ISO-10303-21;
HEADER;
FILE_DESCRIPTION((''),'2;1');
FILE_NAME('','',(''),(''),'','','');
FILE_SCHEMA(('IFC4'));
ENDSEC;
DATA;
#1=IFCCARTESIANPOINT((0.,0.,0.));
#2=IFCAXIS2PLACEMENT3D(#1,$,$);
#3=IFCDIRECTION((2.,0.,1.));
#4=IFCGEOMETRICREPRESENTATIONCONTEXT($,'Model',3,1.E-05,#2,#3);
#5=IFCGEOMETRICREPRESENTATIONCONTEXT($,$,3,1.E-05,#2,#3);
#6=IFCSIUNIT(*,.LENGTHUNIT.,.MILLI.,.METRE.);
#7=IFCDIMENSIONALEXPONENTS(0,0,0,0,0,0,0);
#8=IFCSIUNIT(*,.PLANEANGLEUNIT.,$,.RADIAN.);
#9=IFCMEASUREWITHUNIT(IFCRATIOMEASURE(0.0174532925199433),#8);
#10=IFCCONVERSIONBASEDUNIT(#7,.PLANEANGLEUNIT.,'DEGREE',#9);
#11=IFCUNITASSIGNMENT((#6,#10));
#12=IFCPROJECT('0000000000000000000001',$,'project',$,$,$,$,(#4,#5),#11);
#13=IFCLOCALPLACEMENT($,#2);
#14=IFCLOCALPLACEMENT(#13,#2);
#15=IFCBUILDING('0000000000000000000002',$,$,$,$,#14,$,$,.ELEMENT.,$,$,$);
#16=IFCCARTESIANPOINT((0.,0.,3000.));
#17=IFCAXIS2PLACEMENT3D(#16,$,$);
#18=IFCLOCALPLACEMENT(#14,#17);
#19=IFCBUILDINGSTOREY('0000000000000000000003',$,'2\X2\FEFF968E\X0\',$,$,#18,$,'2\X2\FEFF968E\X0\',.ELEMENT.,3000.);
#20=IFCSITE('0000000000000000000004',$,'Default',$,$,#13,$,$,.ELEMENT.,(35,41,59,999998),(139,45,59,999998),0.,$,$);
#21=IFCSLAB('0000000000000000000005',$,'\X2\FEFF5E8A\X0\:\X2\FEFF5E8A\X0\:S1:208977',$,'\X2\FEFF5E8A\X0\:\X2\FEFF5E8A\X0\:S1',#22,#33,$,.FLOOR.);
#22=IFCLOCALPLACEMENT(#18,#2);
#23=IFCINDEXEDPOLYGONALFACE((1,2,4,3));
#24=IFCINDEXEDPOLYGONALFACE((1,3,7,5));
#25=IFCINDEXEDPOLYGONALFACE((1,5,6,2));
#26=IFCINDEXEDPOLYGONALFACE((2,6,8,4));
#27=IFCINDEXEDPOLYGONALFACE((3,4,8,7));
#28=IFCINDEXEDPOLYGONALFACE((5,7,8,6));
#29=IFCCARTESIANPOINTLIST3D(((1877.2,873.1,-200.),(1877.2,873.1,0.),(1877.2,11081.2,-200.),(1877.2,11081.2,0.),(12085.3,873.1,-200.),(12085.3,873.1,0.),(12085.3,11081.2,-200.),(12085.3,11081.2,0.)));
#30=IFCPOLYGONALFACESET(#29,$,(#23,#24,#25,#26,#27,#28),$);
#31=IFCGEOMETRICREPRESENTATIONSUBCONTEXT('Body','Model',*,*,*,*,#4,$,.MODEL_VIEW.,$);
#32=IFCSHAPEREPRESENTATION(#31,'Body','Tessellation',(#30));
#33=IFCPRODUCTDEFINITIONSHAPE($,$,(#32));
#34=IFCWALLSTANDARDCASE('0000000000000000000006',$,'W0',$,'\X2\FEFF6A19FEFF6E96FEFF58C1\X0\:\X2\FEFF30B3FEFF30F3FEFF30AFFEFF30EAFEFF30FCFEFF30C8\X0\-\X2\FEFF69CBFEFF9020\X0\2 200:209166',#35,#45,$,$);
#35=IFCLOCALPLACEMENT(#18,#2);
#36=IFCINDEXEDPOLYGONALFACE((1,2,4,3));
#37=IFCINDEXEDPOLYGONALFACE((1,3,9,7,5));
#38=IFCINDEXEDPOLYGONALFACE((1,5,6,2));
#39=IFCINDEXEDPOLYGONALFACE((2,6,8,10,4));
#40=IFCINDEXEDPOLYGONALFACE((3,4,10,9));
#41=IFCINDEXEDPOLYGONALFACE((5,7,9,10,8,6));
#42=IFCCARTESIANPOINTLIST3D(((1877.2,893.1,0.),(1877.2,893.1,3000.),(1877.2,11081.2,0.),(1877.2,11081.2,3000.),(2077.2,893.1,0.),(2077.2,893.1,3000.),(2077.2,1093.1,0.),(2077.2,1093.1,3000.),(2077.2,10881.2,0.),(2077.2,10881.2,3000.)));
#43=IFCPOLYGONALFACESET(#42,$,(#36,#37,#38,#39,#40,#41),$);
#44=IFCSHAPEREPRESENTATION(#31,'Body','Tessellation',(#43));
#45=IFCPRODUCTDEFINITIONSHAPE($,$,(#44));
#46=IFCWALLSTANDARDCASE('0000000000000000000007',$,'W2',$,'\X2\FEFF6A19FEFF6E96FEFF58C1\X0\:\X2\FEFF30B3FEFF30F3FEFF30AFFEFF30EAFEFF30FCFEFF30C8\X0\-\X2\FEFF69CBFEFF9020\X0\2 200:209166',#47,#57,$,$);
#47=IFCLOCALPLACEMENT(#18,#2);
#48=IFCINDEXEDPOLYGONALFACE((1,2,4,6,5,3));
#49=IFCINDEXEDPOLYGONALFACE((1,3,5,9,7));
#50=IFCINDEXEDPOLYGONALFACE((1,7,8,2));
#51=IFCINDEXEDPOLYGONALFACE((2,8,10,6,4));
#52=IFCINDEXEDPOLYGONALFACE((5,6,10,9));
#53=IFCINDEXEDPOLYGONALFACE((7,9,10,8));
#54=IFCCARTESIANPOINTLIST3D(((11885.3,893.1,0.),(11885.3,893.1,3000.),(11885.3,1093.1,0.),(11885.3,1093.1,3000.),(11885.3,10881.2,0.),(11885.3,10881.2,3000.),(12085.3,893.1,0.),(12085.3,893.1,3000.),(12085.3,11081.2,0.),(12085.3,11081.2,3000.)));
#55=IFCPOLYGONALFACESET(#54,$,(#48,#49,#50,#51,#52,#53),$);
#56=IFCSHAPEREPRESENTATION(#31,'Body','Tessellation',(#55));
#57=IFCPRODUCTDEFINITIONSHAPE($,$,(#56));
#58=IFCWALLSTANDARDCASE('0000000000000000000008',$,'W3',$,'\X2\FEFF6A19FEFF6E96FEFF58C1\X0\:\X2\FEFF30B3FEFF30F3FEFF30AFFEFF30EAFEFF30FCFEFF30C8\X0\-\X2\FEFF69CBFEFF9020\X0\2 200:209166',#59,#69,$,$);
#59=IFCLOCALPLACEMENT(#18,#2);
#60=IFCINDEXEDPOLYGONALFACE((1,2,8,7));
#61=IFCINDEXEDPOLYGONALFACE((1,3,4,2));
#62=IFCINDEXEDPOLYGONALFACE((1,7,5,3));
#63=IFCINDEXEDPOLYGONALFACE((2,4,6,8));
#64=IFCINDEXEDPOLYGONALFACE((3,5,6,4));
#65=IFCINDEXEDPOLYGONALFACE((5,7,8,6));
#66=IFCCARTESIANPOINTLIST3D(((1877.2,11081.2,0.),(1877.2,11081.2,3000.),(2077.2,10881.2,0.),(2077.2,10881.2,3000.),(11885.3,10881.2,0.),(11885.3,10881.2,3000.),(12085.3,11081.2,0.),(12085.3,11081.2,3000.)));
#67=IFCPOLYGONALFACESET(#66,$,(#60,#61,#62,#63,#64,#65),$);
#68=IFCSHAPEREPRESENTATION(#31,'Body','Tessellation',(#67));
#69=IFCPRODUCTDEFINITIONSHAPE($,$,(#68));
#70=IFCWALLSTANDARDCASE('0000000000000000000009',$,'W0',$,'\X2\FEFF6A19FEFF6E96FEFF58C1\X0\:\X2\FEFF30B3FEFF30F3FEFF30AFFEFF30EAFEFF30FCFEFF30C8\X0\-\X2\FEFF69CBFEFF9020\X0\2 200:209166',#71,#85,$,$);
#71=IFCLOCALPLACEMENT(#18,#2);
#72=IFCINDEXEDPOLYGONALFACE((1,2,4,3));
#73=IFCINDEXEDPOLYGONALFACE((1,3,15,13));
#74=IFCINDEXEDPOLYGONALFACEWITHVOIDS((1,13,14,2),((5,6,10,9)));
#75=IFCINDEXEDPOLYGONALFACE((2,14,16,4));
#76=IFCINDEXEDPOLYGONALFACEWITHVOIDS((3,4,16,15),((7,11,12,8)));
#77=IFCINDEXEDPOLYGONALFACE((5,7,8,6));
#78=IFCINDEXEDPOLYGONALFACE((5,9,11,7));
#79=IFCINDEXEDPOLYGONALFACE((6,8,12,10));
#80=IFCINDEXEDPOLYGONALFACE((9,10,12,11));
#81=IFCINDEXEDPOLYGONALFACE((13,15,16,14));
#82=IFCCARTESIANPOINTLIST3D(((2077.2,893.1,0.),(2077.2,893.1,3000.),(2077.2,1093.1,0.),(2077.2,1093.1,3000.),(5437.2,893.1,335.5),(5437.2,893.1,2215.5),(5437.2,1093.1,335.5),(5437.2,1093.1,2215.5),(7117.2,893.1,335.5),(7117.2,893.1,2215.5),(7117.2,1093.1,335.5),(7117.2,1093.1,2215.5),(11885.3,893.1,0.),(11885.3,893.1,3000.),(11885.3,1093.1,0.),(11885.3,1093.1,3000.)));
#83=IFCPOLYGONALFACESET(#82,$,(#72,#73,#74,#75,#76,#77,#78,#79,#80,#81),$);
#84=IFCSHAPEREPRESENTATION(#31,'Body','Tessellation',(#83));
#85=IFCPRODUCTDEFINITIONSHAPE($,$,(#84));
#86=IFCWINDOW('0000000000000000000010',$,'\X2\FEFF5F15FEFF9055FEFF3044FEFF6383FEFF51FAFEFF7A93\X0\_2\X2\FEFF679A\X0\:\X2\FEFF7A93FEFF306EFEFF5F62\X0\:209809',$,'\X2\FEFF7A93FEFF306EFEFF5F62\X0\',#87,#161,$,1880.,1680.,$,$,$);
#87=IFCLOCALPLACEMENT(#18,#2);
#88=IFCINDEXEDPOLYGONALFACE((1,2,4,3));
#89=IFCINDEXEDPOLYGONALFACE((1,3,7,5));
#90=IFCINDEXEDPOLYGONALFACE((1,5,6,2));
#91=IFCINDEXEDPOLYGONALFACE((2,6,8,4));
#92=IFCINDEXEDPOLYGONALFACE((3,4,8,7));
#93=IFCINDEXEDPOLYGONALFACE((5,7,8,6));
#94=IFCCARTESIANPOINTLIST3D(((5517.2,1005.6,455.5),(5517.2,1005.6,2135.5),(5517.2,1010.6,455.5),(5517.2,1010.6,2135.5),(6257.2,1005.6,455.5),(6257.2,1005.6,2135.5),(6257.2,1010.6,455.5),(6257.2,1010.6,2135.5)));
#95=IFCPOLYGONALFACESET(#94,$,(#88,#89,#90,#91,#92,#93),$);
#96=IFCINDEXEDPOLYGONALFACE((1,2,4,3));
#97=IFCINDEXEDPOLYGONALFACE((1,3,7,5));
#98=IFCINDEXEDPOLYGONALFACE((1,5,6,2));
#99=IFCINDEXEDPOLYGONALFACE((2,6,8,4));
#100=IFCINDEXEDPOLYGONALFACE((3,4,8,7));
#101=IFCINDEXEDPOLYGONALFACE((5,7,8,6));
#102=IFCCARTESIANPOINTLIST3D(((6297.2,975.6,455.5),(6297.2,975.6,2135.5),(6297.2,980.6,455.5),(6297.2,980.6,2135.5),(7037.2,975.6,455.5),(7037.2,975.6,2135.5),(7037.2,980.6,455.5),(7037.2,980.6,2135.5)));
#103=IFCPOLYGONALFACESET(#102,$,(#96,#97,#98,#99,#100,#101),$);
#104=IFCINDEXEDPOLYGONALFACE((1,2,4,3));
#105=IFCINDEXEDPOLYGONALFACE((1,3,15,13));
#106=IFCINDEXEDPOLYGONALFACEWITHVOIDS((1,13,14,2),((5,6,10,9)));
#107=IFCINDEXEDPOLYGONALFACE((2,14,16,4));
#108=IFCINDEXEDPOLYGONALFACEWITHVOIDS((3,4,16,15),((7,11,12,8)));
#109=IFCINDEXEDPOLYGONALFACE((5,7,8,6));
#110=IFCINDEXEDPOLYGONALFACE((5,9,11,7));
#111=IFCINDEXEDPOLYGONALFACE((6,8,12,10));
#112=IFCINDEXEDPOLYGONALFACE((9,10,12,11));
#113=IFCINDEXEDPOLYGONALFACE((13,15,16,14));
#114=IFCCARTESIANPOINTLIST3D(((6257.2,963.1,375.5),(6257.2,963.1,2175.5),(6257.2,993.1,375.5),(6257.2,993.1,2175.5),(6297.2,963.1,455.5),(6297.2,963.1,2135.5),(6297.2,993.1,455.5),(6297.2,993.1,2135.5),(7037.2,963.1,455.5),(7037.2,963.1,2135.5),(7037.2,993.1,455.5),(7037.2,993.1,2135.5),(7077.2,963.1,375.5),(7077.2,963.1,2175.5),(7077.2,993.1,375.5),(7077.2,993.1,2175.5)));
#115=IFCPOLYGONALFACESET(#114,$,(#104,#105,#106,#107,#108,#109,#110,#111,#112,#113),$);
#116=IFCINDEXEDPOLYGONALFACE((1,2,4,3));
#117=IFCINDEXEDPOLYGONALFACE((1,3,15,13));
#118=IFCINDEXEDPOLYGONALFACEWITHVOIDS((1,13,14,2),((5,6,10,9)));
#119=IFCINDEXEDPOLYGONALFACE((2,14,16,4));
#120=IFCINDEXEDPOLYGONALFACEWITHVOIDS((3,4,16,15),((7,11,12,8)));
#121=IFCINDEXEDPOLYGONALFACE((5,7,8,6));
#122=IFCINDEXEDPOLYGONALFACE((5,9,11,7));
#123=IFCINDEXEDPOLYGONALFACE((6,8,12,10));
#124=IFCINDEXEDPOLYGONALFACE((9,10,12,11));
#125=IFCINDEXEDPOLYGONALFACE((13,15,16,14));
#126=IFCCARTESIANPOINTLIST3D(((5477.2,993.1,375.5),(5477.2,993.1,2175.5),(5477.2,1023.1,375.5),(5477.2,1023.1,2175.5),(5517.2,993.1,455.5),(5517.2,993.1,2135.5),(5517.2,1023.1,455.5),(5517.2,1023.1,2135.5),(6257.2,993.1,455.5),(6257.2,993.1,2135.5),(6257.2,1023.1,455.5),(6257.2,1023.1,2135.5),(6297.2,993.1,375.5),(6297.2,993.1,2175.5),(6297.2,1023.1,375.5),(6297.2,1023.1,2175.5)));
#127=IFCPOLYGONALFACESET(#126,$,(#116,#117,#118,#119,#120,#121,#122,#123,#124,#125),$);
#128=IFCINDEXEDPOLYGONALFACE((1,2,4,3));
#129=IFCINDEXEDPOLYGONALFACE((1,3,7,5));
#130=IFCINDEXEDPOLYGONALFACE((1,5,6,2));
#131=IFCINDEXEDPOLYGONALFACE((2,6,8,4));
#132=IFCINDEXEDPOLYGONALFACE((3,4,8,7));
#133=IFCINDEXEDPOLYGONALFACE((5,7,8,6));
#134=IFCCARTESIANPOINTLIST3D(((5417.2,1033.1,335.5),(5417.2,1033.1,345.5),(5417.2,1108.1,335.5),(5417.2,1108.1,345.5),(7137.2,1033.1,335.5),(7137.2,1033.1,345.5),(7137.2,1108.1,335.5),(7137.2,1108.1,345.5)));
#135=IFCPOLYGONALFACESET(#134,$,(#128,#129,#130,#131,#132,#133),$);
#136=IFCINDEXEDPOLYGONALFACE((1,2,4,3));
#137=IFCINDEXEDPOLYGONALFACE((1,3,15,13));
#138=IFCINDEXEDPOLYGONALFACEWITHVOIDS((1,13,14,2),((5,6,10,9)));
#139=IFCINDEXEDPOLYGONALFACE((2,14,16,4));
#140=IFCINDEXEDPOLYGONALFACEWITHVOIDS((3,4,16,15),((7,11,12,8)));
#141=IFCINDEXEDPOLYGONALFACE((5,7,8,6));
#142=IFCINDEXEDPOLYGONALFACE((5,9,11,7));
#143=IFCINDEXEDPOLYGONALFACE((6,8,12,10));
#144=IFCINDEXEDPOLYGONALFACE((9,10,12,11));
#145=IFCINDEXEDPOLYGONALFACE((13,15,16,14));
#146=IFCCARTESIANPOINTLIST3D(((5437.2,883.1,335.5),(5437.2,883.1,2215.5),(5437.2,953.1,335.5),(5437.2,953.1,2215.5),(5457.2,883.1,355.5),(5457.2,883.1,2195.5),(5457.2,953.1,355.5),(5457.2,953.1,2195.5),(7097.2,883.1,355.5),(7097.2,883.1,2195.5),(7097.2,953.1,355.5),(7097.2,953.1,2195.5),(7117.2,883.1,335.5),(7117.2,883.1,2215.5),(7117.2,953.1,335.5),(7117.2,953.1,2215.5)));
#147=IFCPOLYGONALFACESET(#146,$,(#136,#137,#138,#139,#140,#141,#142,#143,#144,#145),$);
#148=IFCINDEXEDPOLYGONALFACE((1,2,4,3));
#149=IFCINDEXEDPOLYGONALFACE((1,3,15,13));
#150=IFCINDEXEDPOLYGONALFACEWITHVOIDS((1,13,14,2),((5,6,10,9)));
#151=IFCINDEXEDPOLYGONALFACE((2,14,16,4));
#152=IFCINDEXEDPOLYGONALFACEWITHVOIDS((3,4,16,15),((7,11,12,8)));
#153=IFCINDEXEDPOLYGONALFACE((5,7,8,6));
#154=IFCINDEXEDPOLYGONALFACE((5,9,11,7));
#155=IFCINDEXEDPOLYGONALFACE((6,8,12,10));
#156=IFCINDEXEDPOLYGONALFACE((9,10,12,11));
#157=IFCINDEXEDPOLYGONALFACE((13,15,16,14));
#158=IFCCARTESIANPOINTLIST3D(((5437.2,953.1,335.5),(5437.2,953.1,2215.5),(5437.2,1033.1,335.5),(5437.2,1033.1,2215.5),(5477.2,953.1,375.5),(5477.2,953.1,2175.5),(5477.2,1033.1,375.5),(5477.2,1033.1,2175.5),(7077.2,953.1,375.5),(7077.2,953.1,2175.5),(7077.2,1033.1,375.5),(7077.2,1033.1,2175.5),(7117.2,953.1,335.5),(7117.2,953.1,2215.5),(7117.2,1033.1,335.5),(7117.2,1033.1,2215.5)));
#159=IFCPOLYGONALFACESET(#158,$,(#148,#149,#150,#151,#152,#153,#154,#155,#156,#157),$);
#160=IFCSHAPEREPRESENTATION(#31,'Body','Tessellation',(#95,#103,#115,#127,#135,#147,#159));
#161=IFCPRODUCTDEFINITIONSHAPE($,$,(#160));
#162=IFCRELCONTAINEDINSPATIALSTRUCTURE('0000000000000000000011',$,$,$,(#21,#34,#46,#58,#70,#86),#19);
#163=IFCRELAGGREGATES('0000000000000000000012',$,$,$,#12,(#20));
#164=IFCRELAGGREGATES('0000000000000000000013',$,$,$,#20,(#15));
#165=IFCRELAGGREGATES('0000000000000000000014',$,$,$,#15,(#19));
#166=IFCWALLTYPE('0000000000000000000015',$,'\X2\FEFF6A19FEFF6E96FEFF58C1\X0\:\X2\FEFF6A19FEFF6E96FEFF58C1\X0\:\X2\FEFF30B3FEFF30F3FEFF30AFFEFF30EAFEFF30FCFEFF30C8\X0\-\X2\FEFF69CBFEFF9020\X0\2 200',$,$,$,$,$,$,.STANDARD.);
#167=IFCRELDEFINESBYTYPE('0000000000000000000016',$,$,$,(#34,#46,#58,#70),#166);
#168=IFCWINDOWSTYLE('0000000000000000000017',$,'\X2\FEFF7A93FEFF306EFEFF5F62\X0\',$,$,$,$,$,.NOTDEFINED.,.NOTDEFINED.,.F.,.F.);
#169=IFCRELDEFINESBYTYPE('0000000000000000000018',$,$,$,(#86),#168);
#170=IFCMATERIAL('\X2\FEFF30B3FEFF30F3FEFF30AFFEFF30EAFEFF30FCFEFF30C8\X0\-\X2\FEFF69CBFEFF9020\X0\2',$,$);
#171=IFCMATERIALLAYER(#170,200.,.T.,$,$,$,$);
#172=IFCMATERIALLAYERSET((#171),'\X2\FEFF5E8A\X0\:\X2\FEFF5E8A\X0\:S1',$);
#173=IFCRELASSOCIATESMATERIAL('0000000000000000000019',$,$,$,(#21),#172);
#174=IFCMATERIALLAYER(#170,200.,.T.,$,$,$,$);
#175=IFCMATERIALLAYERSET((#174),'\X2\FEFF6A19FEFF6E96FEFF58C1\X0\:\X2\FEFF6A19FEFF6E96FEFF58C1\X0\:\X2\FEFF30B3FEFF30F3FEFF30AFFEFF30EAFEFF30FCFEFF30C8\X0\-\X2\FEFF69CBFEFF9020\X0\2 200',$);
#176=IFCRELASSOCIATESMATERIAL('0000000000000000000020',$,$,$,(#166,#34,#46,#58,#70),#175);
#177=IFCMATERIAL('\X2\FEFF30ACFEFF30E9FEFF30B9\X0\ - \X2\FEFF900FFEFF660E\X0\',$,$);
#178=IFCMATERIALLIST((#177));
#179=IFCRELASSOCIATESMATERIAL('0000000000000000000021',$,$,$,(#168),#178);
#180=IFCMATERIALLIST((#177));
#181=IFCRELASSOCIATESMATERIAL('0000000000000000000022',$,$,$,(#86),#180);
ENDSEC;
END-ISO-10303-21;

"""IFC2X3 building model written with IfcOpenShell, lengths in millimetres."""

from ifc_helpers import new_model, entity, si_unit, converted_unit, direction, frame, frame_2d, origin, origin_2d_with_axis, place, context, subcontext, project, spatial, polyline, rectangle, outline, extrude, source, transform, mapped, material, material_list, layer, layer_set, layer_usage, type_object, type_shapes, element, fill, save


model = new_model("IFC2X3")

# Units and contexts
model_context = context("Model", 3, precision=1e-05, world=origin(), true_north=direction((2.0, 0.0, 1.0)))
context_of_model = context(None, 3, precision=1e-05, world=origin(), true_north=direction((2.0, 0.0, 1.0)))
body_context = subcontext(model_context, "Body", "Model", "MODEL_VIEW")
ifc_project = project(units=[si_unit("LENGTHUNIT", "METRE", prefix="MILLI"), converted_unit("PLANEANGLEUNIT", "DEGREE", entity("IfcRatioMeasure", 0.0174532925199433), si_unit("PLANEANGLEUNIT", "RADIAN"), dimensions=[0, 0, 0, 0, 0, 0, 0])], contexts=[model_context, context_of_model])

# Site, building, storey
site_placement = place(None, origin())
site = spatial("IfcSite", under=ifc_project, at=site_placement, Name="Default", CompositionType="ELEMENT", RefLatitude=(35, 41, 59, 999998), RefLongitude=(139, 45, 59, 999998), RefElevation=0.0)
building_placement = place(site_placement, origin())
building = spatial("IfcBuilding", under=site, at=building_placement, CompositionType="ELEMENT")
storey_placement = place(building_placement, frame((0.0, 0.0, 3000.0)))
storey = spatial("IfcBuildingStorey", under=building, at=storey_placement, Name="2\ufeff階", LongName="2\ufeff階", CompositionType="ELEMENT", Elevation=3000.0)

# Slab
ifc_material_1 = material(Name="\ufeffコ\ufeffン\ufeffク\ufeffリ\ufeffー\ufeffト-\ufeff構\ufeff造2")
ifc_layer_1 = layer(ifc_material_1, 200.0, ventilated=True)
ifc_layer_set_1 = layer_set([ifc_layer_1], Name="\ufeff床:\ufeff床:S1")
ifc_layer_usage_1 = layer_usage(ifc_layer_set_1, "AXIS3", "POSITIVE", 0.0)
slab_1_placement = place(storey_placement, origin())
element("IfcSlab", 1, at=slab_1_placement, inside=storey, material=ifc_layer_usage_1, Name="\ufeff床:\ufeff床:S1:208977", ObjectType="\ufeff床:\ufeff床:S1", PredefinedType="FLOOR", context=body_context, shape_type="SweptSolid", body=[
    extrude(rectangle(XDim=10208.1, YDim=10208.1, at=origin_2d_with_axis()), frame((6981.3, 5977.2, 0.0), z_axis=(0.0, 0.0, -1.0), x_axis=(0.0, 1.0, 0.0)), (0.0, 0.0, 1.0), 200.0),
])

# Walls
ifc_layer_2 = layer(ifc_material_1, 200.0, ventilated=True)
ifc_layer_set_2 = layer_set([ifc_layer_2], Name="\ufeff標\ufeff準\ufeff壁:\ufeff標\ufeff準\ufeff壁:\ufeffコ\ufeffン\ufeffク\ufeffリ\ufeffー\ufeffト-\ufeff構\ufeff造2 200")
ifc_layer_usage_2 = layer_usage(ifc_layer_set_2, "AXIS2", "NEGATIVE", 100.0)
wall_type = type_object("IfcWallType", Name="\ufeff標\ufeff準\ufeff壁:\ufeff標\ufeff準\ufeff壁:\ufeffコ\ufeffン\ufeffク\ufeffリ\ufeffー\ufeffト-\ufeff構\ufeff造2 200", PredefinedType="STANDARD", material=ifc_layer_set_2)
wall_1_placement = place(storey_placement, frame((1977.2, 11081.2, 0.0), z_axis=(0.0, 0.0, 1.0), x_axis=(0.0, -1.0, 0.0)))
element("IfcWallStandardCase", 2, at=wall_1_placement, inside=storey, type_object=wall_type, material=ifc_layer_usage_2, Name="W0", ObjectType="\ufeff標\ufeff準\ufeff壁:\ufeffコ\ufeffン\ufeffク\ufeffリ\ufeffー\ufeffト-\ufeff構\ufeff造2 200:209166", context=body_context, shape_type="SweptSolid", body=[
    extrude(outline(polyline([(10188.1, -100.0), (10188.1, 100.0), (9988.1, 100.0), (200.0, 100.0), (0.0, -100.0), (10188.1, -100.0)])), origin(), (0.0, 0.0, 1.0), 3000.0),
])
ifc_layer_usage_3 = layer_usage(ifc_layer_set_2, "AXIS2", "NEGATIVE", 100.0)
wall_2_placement = place(storey_placement, frame((11985.3, 893.1, 0.0), z_axis=(0.0, 0.0, 1.0), x_axis=(0.0, 1.0, 0.0)))
element("IfcWallStandardCase", 3, at=wall_2_placement, inside=storey, type_object=wall_type, material=ifc_layer_usage_3, Name="W2", ObjectType="\ufeff標\ufeff準\ufeff壁:\ufeffコ\ufeffン\ufeffク\ufeffリ\ufeffー\ufeffト-\ufeff構\ufeff造2 200:209166", context=body_context, shape_type="SweptSolid", body=[
    extrude(outline(polyline([(10188.1, -100.0), (9988.1, 100.0), (200.0, 100.0), (0.0, 100.0), (0.0, -100.0), (10188.1, -100.0)])), origin(), (0.0, 0.0, 1.0), 3000.0),
])
ifc_layer_usage_4 = layer_usage(ifc_layer_set_2, "AXIS2", "NEGATIVE", 100.0)
wall_3_placement = place(storey_placement, frame((12085.3, 10981.2, 0.0), z_axis=(0.0, 0.0, 1.0), x_axis=(-1.0, 0.0, 0.0)))
element("IfcWallStandardCase", 4, at=wall_3_placement, inside=storey, type_object=wall_type, material=ifc_layer_usage_4, Name="W3", ObjectType="\ufeff標\ufeff準\ufeff壁:\ufeffコ\ufeffン\ufeffク\ufeffリ\ufeffー\ufeffト-\ufeff構\ufeff造2 200:209166", context=body_context, shape_type="SweptSolid", body=[
    extrude(outline(polyline([(10208.1, -100.0), (10008.1, 100.0), (200.0, 100.0), (0.0, -100.0), (10208.1, -100.0)])), origin(), (0.0, 0.0, 1.0), 3000.0),
])

# Wall, opening, window
ifc_layer_usage_5 = layer_usage(ifc_layer_set_2, "AXIS2", "NEGATIVE", 100.0)
wall_4_placement = place(storey_placement, frame((2077.2, 993.1, 0.0)))
wall_4 = element("IfcWallStandardCase", 5, at=wall_4_placement, inside=storey, type_object=wall_type, material=ifc_layer_usage_5, Name="W0", ObjectType="\ufeff標\ufeff準\ufeff壁:\ufeffコ\ufeffン\ufeffク\ufeffリ\ufeffー\ufeffト-\ufeff構\ufeff造2 200:209166", context=body_context, shape_type="SweptSolid", body=[
    extrude(rectangle(XDim=9808.1, YDim=200.0, at=frame_2d((4904.0, 0.0), x_axis=(-1.0, 0.0))), origin(), (0.0, 0.0, 1.0), 3000.0),
])
opening_placement = place(wall_4_placement, frame((3360.0, -100.0, 335.5)))
opening = element("IfcOpeningElement", 6, at=opening_placement, cuts=wall_4, ObjectType="Opening", context=body_context, shape_type="SweptSolid", body=[
    extrude(rectangle(XDim=1880.0, YDim=1680.0, at=frame_2d((940.0, 840.0), x_axis=(-1.0, 0.0))), frame((0.0, 0.0, 0.0), z_axis=(0.0, 1.0, 0.0), x_axis=(0.0, 0.0, 1.0)), (0.0, 0.0, 1.0), 200.0),
])
ifc_material_2 = material(Name="\ufeffガ\ufeffラ\ufeffス - \ufeff透\ufeff明")
ifc_material_list_1 = material_list([ifc_material_2])
ifc_material_list_2 = material_list([ifc_material_2])
window_style = type_object("IfcWindowStyle", Name="\ufeff窓\ufeffの\ufeff形", ConstructionType="NOTDEFINED", OperationType="NOTDEFINED", ParameterTakesPrecedence=False, Sizeable=False, material=ifc_material_list_2)
shared_shape = source(origin(), body_context, "Body", "SweptSolid", [
    extrude(rectangle(XDim=5.0, YDim=740.0, at=frame_2d((0.0, 0.0), x_axis=(1.0, 0.0))), frame((450.0, 115.0, 120.0), z_axis=(0.0, 0.0, 1.0), x_axis=(0.0, 1.0, 0.0)), (0.0, 0.0, 1.0), 1680.0),
    extrude(rectangle(XDim=5.0, YDim=740.0, at=frame_2d((0.0, 0.0), x_axis=(1.0, 0.0))), frame((1230.0, 85.0, 120.0), z_axis=(0.0, 0.0, 1.0), x_axis=(0.0, 1.0, 0.0)), (0.0, 0.0, 1.0), 1680.0),
    extrude(outline(polyline([(-410.0, -900.0), (410.0, -900.0), (410.0, 900.0), (-410.0, 900.0), (-410.0, -900.0)]), holes=[polyline([(370.0, 820.0), (370.0, -860.0), (-370.0, -860.0), (-370.0, 820.0), (370.0, 820.0)])]), frame((1230.0, 70.0, 940.0), z_axis=(0.0, 1.0, 0.0), x_axis=(1.0, 0.0, 0.0)), (0.0, 0.0, 1.0), 30.0),
    extrude(outline(polyline([(-410.0, -900.0), (410.0, -900.0), (410.0, 900.0), (-410.0, 900.0), (-410.0, -900.0)]), holes=[polyline([(370.0, 820.0), (370.0, -860.0), (-370.0, -860.0), (-370.0, 820.0), (370.0, 820.0)])]), frame((450.0, 100.0, 940.0), z_axis=(0.0, 1.0, 0.0), x_axis=(1.0, 0.0, 0.0)), (0.0, 0.0, 1.0), 30.0),
    extrude(rectangle(XDim=1720.0, YDim=75.0, at=frame_2d((0.0, 0.0), x_axis=(1.0, 0.0))), frame((840.0, 177.5, 0.0), z_axis=(0.0, 0.0, 1.0), x_axis=(-1.0, 0.0, 0.0)), (0.0, 0.0, 1.0), 10.0),
    extrude(outline(polyline([(-940.0, -840.0), (940.0, -840.0), (940.0, 840.0), (-940.0, 840.0), (-940.0, -840.0)]), holes=[polyline([(920.0, 820.0), (920.0, -820.0), (-920.0, -820.0), (-920.0, 820.0), (920.0, 820.0)])]), frame((840.0, -10.0, 940.0), z_axis=(0.0, 1.0, 0.0), x_axis=(0.0, 0.0, -1.0)), (0.0, 0.0, 1.0), 70.0),
    extrude(outline(polyline([(-840.0, -940.0), (840.0, -940.0), (840.0, 940.0), (-840.0, 940.0), (-840.0, -940.0)]), holes=[polyline([(800.0, -900.0), (-800.0, -900.0), (-800.0, 900.0), (800.0, 900.0), (800.0, -900.0)])]), frame((840.0, 60.0, 940.0), z_axis=(0.0, 1.0, 0.0), x_axis=(1.0, 0.0, 0.0)), (0.0, 0.0, 1.0), 80.0),
])
type_shapes(window_style, [shared_shape])
window_placement = place(storey_placement, frame((5437.2, 893.1, 335.5)))
window = element("IfcWindow", 7, at=window_placement, inside=storey, type_object=window_style, material=ifc_material_list_1, Name="\ufeff引\ufeff違\ufeffい\ufeff掃\ufeff出\ufeff窓_2\ufeff枚:\ufeff窓\ufeffの\ufeff形:209809", ObjectType="\ufeff窓\ufeffの\ufeff形", OverallHeight=1880.0, OverallWidth=1680.0, context=body_context, shape_type="MappedRepresentation", body=[
    mapped(shared_shape, transform((0.0, 0.0, 0.0), scale=1.0)),
])
fill(opening, window)

save(model, "model.ifc")
